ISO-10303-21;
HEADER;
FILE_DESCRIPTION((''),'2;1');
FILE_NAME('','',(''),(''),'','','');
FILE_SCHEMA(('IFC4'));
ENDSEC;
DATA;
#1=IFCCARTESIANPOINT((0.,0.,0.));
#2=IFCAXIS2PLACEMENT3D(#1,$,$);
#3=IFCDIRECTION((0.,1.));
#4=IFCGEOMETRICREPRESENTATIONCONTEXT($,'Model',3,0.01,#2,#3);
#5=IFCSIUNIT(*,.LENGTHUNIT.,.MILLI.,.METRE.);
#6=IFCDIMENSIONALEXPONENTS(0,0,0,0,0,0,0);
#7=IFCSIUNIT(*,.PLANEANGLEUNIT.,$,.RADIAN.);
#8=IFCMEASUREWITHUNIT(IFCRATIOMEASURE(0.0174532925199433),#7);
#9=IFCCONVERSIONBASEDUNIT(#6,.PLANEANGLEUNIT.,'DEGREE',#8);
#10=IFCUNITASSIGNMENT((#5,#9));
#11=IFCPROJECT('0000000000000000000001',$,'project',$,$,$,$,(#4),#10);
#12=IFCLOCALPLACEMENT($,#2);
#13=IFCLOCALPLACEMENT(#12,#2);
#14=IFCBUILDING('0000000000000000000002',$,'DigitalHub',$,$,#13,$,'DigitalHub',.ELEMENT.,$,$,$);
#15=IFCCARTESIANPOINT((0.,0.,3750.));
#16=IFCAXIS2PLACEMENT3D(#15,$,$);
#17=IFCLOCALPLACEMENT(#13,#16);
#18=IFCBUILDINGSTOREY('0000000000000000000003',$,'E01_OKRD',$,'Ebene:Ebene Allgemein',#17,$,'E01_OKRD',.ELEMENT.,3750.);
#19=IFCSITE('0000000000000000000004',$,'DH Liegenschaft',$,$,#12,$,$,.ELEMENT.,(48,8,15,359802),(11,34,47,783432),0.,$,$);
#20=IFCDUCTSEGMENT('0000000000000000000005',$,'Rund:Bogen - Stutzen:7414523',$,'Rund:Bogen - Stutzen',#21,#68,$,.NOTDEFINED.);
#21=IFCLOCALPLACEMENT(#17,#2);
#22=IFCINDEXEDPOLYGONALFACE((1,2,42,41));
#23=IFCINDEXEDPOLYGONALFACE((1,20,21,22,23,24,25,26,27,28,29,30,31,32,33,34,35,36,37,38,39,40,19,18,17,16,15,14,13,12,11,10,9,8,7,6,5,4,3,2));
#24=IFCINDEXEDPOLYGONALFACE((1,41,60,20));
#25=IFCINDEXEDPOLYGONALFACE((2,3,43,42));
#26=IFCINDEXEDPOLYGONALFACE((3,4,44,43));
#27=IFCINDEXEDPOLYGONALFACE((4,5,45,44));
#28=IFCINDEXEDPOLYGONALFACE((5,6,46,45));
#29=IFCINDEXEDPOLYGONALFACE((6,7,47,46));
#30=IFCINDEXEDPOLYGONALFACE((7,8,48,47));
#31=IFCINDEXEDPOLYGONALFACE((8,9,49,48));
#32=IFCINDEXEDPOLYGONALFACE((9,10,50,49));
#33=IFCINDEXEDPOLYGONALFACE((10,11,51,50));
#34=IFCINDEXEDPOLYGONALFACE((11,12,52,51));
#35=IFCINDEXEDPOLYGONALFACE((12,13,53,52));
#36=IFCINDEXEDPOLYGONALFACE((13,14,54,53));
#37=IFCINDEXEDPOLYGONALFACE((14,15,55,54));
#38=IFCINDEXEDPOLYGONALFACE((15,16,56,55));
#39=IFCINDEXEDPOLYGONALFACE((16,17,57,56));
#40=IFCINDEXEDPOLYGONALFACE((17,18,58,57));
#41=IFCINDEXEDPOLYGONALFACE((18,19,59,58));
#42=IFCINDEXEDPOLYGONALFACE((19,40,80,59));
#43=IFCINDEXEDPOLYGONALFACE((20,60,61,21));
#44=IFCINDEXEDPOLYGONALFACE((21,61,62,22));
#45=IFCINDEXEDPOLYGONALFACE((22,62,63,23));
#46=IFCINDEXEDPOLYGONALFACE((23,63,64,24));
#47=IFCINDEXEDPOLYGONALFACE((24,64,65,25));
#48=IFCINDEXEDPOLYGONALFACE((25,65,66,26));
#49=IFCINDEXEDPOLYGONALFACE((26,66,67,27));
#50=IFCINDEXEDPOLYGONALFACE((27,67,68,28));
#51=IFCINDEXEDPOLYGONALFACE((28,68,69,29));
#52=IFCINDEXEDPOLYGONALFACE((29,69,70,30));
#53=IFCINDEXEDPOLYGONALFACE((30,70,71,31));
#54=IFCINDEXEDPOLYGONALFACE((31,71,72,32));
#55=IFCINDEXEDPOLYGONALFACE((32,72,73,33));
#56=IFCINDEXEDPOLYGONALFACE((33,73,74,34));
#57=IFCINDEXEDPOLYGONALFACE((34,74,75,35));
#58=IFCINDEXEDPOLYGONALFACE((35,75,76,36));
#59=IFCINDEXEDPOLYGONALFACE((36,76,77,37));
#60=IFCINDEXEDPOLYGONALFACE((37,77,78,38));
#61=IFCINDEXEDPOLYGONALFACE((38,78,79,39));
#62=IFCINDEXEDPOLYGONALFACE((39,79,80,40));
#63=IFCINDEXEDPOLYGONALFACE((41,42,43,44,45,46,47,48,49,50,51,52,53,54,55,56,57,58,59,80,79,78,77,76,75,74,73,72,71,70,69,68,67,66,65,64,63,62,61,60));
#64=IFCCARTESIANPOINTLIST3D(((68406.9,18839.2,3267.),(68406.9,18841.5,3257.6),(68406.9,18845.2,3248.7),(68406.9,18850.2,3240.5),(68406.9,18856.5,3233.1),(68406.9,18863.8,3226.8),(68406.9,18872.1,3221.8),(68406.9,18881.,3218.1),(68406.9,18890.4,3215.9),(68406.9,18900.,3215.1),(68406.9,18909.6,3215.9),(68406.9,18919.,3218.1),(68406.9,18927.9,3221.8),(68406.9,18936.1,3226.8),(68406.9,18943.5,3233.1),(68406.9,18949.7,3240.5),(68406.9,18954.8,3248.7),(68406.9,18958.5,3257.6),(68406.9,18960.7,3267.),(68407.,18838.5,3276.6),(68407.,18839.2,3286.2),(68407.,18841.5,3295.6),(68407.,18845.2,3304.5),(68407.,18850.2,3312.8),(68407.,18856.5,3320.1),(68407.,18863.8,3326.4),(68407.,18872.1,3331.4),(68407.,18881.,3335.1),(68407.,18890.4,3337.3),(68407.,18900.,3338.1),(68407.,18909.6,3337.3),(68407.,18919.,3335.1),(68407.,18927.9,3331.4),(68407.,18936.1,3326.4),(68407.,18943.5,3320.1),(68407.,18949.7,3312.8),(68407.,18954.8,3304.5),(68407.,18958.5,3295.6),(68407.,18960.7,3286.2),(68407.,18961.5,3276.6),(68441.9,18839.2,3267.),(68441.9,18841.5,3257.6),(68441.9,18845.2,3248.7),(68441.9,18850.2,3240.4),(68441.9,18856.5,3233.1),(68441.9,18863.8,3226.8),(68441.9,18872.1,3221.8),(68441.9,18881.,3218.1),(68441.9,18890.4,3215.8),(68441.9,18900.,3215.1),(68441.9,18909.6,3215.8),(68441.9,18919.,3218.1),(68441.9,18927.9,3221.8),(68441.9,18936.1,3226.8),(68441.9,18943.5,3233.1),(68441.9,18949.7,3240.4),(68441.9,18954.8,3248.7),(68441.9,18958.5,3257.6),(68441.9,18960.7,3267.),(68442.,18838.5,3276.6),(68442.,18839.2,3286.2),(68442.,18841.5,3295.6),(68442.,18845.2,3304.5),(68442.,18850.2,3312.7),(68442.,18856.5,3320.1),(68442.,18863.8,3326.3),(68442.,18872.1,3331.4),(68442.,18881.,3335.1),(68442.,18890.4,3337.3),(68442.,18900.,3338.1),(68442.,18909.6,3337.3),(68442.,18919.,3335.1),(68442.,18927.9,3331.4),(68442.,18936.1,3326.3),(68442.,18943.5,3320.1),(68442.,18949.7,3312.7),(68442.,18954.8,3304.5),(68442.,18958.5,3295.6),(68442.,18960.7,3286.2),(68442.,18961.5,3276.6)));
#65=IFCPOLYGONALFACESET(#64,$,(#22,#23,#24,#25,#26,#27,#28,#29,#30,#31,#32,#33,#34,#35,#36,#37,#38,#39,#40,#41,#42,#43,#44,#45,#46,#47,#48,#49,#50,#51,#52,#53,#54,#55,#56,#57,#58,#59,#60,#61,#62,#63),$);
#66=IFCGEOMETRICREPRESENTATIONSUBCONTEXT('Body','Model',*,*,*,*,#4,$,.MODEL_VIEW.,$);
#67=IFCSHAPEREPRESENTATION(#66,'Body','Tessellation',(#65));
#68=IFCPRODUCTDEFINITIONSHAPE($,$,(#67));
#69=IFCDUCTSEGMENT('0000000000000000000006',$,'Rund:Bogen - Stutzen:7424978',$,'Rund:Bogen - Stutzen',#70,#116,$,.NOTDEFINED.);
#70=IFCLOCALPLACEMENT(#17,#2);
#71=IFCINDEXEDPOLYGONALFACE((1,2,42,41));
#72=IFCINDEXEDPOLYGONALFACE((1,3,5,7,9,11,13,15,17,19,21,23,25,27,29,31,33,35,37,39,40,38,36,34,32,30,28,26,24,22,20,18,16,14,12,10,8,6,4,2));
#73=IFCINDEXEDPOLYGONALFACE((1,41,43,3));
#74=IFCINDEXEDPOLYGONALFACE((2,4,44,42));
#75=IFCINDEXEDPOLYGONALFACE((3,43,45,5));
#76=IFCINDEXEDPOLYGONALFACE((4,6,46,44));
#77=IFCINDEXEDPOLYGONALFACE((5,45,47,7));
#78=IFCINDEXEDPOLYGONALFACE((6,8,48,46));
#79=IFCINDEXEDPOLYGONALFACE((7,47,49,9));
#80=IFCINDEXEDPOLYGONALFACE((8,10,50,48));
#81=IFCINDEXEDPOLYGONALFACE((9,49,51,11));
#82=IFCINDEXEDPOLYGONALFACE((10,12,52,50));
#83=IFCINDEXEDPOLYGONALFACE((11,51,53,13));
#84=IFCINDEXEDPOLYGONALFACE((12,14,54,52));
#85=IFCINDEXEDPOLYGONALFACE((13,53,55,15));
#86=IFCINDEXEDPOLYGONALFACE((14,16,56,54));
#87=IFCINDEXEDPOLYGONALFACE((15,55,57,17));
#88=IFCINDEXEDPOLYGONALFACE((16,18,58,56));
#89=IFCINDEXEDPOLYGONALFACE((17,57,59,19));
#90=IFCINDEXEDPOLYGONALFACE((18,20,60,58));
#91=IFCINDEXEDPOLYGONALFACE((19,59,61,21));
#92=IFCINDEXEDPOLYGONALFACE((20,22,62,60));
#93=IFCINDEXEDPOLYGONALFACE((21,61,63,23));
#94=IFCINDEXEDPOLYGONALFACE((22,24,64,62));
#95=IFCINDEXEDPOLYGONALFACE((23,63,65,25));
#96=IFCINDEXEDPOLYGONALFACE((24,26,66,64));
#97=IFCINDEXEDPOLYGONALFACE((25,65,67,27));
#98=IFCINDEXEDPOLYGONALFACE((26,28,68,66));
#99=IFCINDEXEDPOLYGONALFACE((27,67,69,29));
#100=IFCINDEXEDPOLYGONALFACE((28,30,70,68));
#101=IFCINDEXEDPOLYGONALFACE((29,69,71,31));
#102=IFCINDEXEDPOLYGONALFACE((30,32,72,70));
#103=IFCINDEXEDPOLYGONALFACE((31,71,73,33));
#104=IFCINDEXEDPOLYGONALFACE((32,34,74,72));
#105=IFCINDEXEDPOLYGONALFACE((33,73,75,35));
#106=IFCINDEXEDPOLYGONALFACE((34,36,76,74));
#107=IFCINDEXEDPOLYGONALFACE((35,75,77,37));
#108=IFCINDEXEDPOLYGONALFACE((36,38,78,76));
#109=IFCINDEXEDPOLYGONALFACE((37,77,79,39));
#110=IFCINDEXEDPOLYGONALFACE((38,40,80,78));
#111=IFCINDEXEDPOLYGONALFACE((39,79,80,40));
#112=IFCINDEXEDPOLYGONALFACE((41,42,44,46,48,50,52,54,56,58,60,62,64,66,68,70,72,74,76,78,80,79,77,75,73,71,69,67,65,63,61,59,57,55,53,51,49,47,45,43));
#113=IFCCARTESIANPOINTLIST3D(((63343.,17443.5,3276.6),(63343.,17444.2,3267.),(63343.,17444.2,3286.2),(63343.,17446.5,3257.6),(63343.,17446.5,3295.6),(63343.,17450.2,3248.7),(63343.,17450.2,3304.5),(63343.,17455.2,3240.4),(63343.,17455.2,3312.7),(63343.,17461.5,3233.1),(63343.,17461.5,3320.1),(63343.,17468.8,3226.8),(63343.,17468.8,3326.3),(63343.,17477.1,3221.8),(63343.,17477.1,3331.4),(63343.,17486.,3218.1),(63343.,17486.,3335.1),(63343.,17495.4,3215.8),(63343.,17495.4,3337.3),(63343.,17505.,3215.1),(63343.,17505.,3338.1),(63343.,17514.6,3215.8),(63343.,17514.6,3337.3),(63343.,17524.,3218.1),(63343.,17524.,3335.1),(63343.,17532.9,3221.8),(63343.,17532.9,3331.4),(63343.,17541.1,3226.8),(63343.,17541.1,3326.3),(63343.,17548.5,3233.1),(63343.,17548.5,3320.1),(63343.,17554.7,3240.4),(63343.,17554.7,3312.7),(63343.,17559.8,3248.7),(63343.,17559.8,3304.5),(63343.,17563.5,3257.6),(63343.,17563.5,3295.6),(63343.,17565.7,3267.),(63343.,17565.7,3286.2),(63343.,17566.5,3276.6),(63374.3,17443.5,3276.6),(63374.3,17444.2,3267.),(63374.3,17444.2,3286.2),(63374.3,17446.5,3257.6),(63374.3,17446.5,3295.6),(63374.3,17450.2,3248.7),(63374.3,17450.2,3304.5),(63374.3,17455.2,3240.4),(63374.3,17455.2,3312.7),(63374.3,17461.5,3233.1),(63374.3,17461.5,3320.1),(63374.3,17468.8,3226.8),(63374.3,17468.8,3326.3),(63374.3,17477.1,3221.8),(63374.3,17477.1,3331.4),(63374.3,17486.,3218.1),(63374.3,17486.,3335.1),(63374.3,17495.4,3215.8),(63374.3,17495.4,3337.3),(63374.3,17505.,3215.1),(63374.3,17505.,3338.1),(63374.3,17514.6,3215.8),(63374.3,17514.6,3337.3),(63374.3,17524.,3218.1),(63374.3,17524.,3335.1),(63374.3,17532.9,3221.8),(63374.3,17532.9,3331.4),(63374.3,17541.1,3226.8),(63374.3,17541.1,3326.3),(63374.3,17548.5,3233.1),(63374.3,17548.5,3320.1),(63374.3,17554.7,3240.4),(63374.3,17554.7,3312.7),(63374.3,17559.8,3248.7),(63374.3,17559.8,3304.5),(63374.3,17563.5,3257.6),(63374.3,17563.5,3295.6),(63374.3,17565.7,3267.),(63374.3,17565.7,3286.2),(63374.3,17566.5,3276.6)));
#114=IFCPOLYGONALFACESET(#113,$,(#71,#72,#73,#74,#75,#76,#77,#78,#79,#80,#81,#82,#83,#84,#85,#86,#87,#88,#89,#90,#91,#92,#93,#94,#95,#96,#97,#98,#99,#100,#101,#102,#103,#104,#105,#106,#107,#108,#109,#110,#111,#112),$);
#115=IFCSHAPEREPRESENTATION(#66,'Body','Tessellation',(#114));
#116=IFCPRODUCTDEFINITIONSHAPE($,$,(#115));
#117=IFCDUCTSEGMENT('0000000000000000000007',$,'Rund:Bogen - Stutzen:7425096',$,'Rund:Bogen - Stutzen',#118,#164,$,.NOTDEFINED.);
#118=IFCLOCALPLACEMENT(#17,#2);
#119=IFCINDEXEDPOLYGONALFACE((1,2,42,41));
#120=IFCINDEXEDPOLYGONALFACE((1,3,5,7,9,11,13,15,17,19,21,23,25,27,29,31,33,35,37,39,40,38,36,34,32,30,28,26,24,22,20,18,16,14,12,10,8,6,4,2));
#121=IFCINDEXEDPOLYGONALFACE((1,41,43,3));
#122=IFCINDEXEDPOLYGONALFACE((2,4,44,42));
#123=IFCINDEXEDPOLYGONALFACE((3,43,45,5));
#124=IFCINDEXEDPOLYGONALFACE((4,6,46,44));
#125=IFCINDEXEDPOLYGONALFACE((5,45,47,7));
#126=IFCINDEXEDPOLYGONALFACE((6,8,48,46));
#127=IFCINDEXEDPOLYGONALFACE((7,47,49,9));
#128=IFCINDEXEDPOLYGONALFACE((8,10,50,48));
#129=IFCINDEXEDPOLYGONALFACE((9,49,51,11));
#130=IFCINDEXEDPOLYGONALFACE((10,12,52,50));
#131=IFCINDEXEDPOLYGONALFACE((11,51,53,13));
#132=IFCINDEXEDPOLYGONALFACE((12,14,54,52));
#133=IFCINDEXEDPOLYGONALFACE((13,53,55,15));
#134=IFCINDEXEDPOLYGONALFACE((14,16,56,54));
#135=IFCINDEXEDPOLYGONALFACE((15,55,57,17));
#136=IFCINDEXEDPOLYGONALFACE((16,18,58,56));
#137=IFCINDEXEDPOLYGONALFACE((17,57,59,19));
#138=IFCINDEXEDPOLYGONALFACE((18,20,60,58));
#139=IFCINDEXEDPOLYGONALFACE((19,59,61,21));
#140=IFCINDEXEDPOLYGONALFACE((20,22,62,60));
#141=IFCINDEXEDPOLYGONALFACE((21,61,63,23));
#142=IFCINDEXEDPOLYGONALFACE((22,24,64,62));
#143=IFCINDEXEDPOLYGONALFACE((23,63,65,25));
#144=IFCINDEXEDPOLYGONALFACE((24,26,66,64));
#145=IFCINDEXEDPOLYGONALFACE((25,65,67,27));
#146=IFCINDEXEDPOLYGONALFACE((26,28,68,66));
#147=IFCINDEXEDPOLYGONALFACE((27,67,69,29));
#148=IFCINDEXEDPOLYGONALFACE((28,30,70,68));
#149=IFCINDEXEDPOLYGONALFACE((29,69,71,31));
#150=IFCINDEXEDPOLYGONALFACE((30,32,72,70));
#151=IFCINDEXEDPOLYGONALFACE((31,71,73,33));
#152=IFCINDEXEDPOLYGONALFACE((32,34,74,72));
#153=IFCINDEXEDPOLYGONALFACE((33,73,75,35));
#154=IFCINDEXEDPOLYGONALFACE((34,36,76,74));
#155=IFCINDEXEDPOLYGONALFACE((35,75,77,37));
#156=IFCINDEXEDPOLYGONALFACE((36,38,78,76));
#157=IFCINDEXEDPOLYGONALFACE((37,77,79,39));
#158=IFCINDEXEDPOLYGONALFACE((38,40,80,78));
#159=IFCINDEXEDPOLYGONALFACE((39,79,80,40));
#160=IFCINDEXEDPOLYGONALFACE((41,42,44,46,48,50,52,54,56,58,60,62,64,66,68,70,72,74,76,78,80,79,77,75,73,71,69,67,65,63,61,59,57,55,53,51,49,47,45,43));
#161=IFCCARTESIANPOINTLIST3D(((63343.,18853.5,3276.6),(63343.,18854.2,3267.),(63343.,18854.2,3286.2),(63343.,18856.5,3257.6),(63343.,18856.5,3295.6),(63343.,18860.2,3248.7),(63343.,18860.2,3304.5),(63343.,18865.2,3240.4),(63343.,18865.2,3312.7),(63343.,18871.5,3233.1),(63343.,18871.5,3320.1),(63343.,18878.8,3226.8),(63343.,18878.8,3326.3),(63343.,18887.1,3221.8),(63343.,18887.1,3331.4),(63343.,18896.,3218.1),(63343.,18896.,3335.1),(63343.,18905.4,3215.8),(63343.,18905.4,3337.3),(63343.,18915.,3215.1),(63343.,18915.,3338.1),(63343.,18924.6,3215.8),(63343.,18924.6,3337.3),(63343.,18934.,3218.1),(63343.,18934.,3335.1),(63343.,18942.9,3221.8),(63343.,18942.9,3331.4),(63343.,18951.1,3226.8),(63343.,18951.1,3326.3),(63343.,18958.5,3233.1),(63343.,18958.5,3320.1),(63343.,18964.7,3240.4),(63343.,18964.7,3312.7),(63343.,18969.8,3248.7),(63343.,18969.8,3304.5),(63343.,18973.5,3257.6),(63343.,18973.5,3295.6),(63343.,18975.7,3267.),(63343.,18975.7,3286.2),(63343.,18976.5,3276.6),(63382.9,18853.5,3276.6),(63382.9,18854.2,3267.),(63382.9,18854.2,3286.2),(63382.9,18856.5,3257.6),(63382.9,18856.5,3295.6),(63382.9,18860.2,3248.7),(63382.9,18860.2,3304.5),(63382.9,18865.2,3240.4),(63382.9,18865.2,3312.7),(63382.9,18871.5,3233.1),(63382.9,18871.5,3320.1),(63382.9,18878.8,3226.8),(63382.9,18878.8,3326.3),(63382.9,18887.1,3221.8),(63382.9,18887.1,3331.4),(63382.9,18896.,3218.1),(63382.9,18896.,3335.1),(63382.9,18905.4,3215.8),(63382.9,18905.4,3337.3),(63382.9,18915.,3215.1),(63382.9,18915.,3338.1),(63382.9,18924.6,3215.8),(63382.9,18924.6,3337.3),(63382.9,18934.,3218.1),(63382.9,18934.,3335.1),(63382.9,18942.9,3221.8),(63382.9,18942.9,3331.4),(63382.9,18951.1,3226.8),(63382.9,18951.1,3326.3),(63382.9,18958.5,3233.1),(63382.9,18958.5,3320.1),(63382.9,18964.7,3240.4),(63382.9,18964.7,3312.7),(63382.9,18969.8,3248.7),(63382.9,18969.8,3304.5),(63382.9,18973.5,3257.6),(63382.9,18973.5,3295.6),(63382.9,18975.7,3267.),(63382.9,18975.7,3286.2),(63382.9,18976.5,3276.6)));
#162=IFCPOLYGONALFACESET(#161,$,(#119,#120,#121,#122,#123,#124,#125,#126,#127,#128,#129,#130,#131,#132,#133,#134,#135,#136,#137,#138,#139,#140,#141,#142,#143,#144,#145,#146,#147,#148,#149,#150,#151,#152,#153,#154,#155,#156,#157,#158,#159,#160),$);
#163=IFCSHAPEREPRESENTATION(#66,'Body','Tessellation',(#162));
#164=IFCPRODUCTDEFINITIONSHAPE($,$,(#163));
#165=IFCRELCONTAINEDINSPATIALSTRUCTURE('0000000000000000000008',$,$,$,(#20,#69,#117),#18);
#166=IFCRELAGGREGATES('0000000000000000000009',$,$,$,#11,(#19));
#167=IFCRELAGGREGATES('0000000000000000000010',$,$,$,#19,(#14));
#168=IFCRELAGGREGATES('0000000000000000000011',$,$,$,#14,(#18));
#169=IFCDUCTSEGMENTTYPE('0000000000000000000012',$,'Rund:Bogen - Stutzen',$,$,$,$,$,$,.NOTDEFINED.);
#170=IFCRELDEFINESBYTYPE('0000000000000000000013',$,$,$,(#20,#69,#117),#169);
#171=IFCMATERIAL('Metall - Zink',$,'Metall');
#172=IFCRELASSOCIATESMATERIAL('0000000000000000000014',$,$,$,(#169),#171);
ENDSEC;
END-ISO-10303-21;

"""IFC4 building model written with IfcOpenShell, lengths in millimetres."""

from ifc_helpers import new_model, entity, si_unit, converted_unit, direction, frame, origin, place, context, subcontext, project, spatial, indexed_curve, outline, extrude, material, type_object, element, save


model = new_model("IFC4")

# Units and contexts
model_context = context("Model", 3, precision=0.01, world=origin(), true_north=direction((0.0, 1.0)))
body_context = subcontext(model_context, "Body", "Model", "MODEL_VIEW")
ifc_project = project(units=[si_unit("LENGTHUNIT", "METRE", prefix="MILLI"), converted_unit("PLANEANGLEUNIT", "DEGREE", entity("IfcRatioMeasure", 0.0174532925199433), si_unit("PLANEANGLEUNIT", "RADIAN"), dimensions=[0, 0, 0, 0, 0, 0, 0])], contexts=[model_context])

# Site, building, storey
site_placement = place(None, origin())
site = spatial("IfcSite", under=ifc_project, at=site_placement, Name="DH Liegenschaft", CompositionType="ELEMENT", RefLatitude=(48, 8, 15, 359802), RefLongitude=(11, 34, 47, 783432), RefElevation=0.0)
building_placement = place(site_placement, origin())
building = spatial("IfcBuilding", under=site, at=building_placement, Name="DigitalHub", LongName="DigitalHub", CompositionType="ELEMENT")
storey_placement = place(building_placement, frame((0.0, 0.0, 3750.0)))
storey = spatial("IfcBuildingStorey", under=building, at=storey_placement, Name="E01_OKRD", ObjectType="Ebene:Ebene Allgemein", LongName="E01_OKRD", CompositionType="ELEMENT", Elevation=3750.0)

# Shared definitions
ifc_material_1 = material(Name="Metall - Zink", Category="Metall")

# Duct segments
duct_segment_type_1 = type_object("IfcDuctSegmentType", Name="Rund:Bogen - Stutzen", PredefinedType="NOTDEFINED", material=ifc_material_1)
duct_segment_1_placement = place(storey_placement, frame((68406.9, 18836.9, 3213.5)))
element("IfcDuctSegment", 1, at=duct_segment_1_placement, inside=storey, type_object=duct_segment_type_1, Name="Rund:Bogen - Stutzen:7414523", ObjectType="Rund:Bogen - Stutzen", PredefinedType="NOTDEFINED", context=body_context, shape_type="SweptSolid", body=[
    extrude(outline(indexed_curve([(61.5, 0.0), (60.7, 9.6), (58.5, 19.0), (54.8, 27.9), (49.8, 36.1), (43.5, 43.5), (36.1, 49.8), (27.9, 54.8), (19.0, 58.5), (9.6, 60.7), (0.0, 61.5), (-9.6, 60.7), (-19.0, 58.5), (-27.9, 54.8), (-36.1, 49.8), (-43.5, 43.5), (-49.8, 36.1), (-54.8, 27.9), (-58.5, 19.0), (-60.7, 9.6), (-61.5, 0.0), (-60.7, -9.6), (-58.5, -19.0), (-54.8, -27.9), (-49.8, -36.1), (-43.5, -43.5), (-36.1, -49.8), (-27.9, -54.8), (-19.0, -58.5), (-9.6, -60.7), (0.0, -61.5), (9.6, -60.7), (19.0, -58.5), (27.9, -54.8), (36.1, -49.8), (43.5, -43.5), (49.8, -36.1), (54.8, -27.9), (58.5, -19.0), (60.7, -9.6), (61.5, 0.0)], self_intersect=False)), frame((35.0, 63.1, 63.1), z_axis=(-1.0, 0.0, 0.000803), x_axis=(0.0, 1.0, 0.0)), (0.0, 0.0, 1.0), 35.0),
])
duct_segment_2_placement = place(storey_placement, frame((63343.0, 17441.9, 3213.5)))
element("IfcDuctSegment", 2, at=duct_segment_2_placement, inside=storey, type_object=duct_segment_type_1, Name="Rund:Bogen - Stutzen:7424978", ObjectType="Rund:Bogen - Stutzen", PredefinedType="NOTDEFINED", context=body_context, shape_type="SweptSolid", body=[
    extrude(outline(indexed_curve([(61.5, 0.0), (60.7, 9.6), (58.5, 19.0), (54.8, 27.9), (49.8, 36.1), (43.5, 43.5), (36.1, 49.8), (27.9, 54.8), (19.0, 58.5), (9.6, 60.7), (0.0, 61.5), (-9.6, 60.7), (-19.0, 58.5), (-27.9, 54.8), (-36.1, 49.8), (-43.5, 43.5), (-49.8, 36.1), (-54.8, 27.9), (-58.5, 19.0), (-60.7, 9.6), (-61.5, 0.0), (-60.7, -9.6), (-58.5, -19.0), (-54.8, -27.9), (-49.8, -36.1), (-43.5, -43.5), (-36.1, -49.8), (-27.9, -54.8), (-19.0, -58.5), (-9.6, -60.7), (0.0, -61.5), (9.6, -60.7), (19.0, -58.5), (27.9, -54.8), (36.1, -49.8), (43.5, -43.5), (49.8, -36.1), (54.8, -27.9), (58.5, -19.0), (60.7, -9.6), (61.5, 0.0)], self_intersect=False)), frame((0.0, 63.1, 63.1), z_axis=(1.0, 0.0, 0.0), x_axis=(0.0, 1.0, 0.0)), (0.0, 0.0, 1.0), 31.3),
])
duct_segment_3_placement = place(storey_placement, frame((63343.0, 18851.9, 3213.5)))
element("IfcDuctSegment", 3, at=duct_segment_3_placement, inside=storey, type_object=duct_segment_type_1, Name="Rund:Bogen - Stutzen:7425096", ObjectType="Rund:Bogen - Stutzen", PredefinedType="NOTDEFINED", context=body_context, shape_type="SweptSolid", body=[
    extrude(outline(indexed_curve([(61.5, 0.0), (60.7, 9.6), (58.5, 19.0), (54.8, 27.9), (49.8, 36.1), (43.5, 43.5), (36.1, 49.8), (27.9, 54.8), (19.0, 58.5), (9.6, 60.7), (0.0, 61.5), (-9.6, 60.7), (-19.0, 58.5), (-27.9, 54.8), (-36.1, 49.8), (-43.5, 43.5), (-49.8, 36.1), (-54.8, 27.9), (-58.5, 19.0), (-60.7, 9.6), (-61.5, 0.0), (-60.7, -9.6), (-58.5, -19.0), (-54.8, -27.9), (-49.8, -36.1), (-43.5, -43.5), (-36.1, -49.8), (-27.9, -54.8), (-19.0, -58.5), (-9.6, -60.7), (0.0, -61.5), (9.6, -60.7), (19.0, -58.5), (27.9, -54.8), (36.1, -49.8), (43.5, -43.5), (49.8, -36.1), (54.8, -27.9), (58.5, -19.0), (60.7, -9.6), (61.5, 0.0)], self_intersect=False)), frame((0.0, 63.1, 63.1), z_axis=(1.0, 0.0, 0.0), x_axis=(0.0, 1.0, 0.0)), (0.0, 0.0, 1.0), 39.9),
])

save(model, "model.ifc")
